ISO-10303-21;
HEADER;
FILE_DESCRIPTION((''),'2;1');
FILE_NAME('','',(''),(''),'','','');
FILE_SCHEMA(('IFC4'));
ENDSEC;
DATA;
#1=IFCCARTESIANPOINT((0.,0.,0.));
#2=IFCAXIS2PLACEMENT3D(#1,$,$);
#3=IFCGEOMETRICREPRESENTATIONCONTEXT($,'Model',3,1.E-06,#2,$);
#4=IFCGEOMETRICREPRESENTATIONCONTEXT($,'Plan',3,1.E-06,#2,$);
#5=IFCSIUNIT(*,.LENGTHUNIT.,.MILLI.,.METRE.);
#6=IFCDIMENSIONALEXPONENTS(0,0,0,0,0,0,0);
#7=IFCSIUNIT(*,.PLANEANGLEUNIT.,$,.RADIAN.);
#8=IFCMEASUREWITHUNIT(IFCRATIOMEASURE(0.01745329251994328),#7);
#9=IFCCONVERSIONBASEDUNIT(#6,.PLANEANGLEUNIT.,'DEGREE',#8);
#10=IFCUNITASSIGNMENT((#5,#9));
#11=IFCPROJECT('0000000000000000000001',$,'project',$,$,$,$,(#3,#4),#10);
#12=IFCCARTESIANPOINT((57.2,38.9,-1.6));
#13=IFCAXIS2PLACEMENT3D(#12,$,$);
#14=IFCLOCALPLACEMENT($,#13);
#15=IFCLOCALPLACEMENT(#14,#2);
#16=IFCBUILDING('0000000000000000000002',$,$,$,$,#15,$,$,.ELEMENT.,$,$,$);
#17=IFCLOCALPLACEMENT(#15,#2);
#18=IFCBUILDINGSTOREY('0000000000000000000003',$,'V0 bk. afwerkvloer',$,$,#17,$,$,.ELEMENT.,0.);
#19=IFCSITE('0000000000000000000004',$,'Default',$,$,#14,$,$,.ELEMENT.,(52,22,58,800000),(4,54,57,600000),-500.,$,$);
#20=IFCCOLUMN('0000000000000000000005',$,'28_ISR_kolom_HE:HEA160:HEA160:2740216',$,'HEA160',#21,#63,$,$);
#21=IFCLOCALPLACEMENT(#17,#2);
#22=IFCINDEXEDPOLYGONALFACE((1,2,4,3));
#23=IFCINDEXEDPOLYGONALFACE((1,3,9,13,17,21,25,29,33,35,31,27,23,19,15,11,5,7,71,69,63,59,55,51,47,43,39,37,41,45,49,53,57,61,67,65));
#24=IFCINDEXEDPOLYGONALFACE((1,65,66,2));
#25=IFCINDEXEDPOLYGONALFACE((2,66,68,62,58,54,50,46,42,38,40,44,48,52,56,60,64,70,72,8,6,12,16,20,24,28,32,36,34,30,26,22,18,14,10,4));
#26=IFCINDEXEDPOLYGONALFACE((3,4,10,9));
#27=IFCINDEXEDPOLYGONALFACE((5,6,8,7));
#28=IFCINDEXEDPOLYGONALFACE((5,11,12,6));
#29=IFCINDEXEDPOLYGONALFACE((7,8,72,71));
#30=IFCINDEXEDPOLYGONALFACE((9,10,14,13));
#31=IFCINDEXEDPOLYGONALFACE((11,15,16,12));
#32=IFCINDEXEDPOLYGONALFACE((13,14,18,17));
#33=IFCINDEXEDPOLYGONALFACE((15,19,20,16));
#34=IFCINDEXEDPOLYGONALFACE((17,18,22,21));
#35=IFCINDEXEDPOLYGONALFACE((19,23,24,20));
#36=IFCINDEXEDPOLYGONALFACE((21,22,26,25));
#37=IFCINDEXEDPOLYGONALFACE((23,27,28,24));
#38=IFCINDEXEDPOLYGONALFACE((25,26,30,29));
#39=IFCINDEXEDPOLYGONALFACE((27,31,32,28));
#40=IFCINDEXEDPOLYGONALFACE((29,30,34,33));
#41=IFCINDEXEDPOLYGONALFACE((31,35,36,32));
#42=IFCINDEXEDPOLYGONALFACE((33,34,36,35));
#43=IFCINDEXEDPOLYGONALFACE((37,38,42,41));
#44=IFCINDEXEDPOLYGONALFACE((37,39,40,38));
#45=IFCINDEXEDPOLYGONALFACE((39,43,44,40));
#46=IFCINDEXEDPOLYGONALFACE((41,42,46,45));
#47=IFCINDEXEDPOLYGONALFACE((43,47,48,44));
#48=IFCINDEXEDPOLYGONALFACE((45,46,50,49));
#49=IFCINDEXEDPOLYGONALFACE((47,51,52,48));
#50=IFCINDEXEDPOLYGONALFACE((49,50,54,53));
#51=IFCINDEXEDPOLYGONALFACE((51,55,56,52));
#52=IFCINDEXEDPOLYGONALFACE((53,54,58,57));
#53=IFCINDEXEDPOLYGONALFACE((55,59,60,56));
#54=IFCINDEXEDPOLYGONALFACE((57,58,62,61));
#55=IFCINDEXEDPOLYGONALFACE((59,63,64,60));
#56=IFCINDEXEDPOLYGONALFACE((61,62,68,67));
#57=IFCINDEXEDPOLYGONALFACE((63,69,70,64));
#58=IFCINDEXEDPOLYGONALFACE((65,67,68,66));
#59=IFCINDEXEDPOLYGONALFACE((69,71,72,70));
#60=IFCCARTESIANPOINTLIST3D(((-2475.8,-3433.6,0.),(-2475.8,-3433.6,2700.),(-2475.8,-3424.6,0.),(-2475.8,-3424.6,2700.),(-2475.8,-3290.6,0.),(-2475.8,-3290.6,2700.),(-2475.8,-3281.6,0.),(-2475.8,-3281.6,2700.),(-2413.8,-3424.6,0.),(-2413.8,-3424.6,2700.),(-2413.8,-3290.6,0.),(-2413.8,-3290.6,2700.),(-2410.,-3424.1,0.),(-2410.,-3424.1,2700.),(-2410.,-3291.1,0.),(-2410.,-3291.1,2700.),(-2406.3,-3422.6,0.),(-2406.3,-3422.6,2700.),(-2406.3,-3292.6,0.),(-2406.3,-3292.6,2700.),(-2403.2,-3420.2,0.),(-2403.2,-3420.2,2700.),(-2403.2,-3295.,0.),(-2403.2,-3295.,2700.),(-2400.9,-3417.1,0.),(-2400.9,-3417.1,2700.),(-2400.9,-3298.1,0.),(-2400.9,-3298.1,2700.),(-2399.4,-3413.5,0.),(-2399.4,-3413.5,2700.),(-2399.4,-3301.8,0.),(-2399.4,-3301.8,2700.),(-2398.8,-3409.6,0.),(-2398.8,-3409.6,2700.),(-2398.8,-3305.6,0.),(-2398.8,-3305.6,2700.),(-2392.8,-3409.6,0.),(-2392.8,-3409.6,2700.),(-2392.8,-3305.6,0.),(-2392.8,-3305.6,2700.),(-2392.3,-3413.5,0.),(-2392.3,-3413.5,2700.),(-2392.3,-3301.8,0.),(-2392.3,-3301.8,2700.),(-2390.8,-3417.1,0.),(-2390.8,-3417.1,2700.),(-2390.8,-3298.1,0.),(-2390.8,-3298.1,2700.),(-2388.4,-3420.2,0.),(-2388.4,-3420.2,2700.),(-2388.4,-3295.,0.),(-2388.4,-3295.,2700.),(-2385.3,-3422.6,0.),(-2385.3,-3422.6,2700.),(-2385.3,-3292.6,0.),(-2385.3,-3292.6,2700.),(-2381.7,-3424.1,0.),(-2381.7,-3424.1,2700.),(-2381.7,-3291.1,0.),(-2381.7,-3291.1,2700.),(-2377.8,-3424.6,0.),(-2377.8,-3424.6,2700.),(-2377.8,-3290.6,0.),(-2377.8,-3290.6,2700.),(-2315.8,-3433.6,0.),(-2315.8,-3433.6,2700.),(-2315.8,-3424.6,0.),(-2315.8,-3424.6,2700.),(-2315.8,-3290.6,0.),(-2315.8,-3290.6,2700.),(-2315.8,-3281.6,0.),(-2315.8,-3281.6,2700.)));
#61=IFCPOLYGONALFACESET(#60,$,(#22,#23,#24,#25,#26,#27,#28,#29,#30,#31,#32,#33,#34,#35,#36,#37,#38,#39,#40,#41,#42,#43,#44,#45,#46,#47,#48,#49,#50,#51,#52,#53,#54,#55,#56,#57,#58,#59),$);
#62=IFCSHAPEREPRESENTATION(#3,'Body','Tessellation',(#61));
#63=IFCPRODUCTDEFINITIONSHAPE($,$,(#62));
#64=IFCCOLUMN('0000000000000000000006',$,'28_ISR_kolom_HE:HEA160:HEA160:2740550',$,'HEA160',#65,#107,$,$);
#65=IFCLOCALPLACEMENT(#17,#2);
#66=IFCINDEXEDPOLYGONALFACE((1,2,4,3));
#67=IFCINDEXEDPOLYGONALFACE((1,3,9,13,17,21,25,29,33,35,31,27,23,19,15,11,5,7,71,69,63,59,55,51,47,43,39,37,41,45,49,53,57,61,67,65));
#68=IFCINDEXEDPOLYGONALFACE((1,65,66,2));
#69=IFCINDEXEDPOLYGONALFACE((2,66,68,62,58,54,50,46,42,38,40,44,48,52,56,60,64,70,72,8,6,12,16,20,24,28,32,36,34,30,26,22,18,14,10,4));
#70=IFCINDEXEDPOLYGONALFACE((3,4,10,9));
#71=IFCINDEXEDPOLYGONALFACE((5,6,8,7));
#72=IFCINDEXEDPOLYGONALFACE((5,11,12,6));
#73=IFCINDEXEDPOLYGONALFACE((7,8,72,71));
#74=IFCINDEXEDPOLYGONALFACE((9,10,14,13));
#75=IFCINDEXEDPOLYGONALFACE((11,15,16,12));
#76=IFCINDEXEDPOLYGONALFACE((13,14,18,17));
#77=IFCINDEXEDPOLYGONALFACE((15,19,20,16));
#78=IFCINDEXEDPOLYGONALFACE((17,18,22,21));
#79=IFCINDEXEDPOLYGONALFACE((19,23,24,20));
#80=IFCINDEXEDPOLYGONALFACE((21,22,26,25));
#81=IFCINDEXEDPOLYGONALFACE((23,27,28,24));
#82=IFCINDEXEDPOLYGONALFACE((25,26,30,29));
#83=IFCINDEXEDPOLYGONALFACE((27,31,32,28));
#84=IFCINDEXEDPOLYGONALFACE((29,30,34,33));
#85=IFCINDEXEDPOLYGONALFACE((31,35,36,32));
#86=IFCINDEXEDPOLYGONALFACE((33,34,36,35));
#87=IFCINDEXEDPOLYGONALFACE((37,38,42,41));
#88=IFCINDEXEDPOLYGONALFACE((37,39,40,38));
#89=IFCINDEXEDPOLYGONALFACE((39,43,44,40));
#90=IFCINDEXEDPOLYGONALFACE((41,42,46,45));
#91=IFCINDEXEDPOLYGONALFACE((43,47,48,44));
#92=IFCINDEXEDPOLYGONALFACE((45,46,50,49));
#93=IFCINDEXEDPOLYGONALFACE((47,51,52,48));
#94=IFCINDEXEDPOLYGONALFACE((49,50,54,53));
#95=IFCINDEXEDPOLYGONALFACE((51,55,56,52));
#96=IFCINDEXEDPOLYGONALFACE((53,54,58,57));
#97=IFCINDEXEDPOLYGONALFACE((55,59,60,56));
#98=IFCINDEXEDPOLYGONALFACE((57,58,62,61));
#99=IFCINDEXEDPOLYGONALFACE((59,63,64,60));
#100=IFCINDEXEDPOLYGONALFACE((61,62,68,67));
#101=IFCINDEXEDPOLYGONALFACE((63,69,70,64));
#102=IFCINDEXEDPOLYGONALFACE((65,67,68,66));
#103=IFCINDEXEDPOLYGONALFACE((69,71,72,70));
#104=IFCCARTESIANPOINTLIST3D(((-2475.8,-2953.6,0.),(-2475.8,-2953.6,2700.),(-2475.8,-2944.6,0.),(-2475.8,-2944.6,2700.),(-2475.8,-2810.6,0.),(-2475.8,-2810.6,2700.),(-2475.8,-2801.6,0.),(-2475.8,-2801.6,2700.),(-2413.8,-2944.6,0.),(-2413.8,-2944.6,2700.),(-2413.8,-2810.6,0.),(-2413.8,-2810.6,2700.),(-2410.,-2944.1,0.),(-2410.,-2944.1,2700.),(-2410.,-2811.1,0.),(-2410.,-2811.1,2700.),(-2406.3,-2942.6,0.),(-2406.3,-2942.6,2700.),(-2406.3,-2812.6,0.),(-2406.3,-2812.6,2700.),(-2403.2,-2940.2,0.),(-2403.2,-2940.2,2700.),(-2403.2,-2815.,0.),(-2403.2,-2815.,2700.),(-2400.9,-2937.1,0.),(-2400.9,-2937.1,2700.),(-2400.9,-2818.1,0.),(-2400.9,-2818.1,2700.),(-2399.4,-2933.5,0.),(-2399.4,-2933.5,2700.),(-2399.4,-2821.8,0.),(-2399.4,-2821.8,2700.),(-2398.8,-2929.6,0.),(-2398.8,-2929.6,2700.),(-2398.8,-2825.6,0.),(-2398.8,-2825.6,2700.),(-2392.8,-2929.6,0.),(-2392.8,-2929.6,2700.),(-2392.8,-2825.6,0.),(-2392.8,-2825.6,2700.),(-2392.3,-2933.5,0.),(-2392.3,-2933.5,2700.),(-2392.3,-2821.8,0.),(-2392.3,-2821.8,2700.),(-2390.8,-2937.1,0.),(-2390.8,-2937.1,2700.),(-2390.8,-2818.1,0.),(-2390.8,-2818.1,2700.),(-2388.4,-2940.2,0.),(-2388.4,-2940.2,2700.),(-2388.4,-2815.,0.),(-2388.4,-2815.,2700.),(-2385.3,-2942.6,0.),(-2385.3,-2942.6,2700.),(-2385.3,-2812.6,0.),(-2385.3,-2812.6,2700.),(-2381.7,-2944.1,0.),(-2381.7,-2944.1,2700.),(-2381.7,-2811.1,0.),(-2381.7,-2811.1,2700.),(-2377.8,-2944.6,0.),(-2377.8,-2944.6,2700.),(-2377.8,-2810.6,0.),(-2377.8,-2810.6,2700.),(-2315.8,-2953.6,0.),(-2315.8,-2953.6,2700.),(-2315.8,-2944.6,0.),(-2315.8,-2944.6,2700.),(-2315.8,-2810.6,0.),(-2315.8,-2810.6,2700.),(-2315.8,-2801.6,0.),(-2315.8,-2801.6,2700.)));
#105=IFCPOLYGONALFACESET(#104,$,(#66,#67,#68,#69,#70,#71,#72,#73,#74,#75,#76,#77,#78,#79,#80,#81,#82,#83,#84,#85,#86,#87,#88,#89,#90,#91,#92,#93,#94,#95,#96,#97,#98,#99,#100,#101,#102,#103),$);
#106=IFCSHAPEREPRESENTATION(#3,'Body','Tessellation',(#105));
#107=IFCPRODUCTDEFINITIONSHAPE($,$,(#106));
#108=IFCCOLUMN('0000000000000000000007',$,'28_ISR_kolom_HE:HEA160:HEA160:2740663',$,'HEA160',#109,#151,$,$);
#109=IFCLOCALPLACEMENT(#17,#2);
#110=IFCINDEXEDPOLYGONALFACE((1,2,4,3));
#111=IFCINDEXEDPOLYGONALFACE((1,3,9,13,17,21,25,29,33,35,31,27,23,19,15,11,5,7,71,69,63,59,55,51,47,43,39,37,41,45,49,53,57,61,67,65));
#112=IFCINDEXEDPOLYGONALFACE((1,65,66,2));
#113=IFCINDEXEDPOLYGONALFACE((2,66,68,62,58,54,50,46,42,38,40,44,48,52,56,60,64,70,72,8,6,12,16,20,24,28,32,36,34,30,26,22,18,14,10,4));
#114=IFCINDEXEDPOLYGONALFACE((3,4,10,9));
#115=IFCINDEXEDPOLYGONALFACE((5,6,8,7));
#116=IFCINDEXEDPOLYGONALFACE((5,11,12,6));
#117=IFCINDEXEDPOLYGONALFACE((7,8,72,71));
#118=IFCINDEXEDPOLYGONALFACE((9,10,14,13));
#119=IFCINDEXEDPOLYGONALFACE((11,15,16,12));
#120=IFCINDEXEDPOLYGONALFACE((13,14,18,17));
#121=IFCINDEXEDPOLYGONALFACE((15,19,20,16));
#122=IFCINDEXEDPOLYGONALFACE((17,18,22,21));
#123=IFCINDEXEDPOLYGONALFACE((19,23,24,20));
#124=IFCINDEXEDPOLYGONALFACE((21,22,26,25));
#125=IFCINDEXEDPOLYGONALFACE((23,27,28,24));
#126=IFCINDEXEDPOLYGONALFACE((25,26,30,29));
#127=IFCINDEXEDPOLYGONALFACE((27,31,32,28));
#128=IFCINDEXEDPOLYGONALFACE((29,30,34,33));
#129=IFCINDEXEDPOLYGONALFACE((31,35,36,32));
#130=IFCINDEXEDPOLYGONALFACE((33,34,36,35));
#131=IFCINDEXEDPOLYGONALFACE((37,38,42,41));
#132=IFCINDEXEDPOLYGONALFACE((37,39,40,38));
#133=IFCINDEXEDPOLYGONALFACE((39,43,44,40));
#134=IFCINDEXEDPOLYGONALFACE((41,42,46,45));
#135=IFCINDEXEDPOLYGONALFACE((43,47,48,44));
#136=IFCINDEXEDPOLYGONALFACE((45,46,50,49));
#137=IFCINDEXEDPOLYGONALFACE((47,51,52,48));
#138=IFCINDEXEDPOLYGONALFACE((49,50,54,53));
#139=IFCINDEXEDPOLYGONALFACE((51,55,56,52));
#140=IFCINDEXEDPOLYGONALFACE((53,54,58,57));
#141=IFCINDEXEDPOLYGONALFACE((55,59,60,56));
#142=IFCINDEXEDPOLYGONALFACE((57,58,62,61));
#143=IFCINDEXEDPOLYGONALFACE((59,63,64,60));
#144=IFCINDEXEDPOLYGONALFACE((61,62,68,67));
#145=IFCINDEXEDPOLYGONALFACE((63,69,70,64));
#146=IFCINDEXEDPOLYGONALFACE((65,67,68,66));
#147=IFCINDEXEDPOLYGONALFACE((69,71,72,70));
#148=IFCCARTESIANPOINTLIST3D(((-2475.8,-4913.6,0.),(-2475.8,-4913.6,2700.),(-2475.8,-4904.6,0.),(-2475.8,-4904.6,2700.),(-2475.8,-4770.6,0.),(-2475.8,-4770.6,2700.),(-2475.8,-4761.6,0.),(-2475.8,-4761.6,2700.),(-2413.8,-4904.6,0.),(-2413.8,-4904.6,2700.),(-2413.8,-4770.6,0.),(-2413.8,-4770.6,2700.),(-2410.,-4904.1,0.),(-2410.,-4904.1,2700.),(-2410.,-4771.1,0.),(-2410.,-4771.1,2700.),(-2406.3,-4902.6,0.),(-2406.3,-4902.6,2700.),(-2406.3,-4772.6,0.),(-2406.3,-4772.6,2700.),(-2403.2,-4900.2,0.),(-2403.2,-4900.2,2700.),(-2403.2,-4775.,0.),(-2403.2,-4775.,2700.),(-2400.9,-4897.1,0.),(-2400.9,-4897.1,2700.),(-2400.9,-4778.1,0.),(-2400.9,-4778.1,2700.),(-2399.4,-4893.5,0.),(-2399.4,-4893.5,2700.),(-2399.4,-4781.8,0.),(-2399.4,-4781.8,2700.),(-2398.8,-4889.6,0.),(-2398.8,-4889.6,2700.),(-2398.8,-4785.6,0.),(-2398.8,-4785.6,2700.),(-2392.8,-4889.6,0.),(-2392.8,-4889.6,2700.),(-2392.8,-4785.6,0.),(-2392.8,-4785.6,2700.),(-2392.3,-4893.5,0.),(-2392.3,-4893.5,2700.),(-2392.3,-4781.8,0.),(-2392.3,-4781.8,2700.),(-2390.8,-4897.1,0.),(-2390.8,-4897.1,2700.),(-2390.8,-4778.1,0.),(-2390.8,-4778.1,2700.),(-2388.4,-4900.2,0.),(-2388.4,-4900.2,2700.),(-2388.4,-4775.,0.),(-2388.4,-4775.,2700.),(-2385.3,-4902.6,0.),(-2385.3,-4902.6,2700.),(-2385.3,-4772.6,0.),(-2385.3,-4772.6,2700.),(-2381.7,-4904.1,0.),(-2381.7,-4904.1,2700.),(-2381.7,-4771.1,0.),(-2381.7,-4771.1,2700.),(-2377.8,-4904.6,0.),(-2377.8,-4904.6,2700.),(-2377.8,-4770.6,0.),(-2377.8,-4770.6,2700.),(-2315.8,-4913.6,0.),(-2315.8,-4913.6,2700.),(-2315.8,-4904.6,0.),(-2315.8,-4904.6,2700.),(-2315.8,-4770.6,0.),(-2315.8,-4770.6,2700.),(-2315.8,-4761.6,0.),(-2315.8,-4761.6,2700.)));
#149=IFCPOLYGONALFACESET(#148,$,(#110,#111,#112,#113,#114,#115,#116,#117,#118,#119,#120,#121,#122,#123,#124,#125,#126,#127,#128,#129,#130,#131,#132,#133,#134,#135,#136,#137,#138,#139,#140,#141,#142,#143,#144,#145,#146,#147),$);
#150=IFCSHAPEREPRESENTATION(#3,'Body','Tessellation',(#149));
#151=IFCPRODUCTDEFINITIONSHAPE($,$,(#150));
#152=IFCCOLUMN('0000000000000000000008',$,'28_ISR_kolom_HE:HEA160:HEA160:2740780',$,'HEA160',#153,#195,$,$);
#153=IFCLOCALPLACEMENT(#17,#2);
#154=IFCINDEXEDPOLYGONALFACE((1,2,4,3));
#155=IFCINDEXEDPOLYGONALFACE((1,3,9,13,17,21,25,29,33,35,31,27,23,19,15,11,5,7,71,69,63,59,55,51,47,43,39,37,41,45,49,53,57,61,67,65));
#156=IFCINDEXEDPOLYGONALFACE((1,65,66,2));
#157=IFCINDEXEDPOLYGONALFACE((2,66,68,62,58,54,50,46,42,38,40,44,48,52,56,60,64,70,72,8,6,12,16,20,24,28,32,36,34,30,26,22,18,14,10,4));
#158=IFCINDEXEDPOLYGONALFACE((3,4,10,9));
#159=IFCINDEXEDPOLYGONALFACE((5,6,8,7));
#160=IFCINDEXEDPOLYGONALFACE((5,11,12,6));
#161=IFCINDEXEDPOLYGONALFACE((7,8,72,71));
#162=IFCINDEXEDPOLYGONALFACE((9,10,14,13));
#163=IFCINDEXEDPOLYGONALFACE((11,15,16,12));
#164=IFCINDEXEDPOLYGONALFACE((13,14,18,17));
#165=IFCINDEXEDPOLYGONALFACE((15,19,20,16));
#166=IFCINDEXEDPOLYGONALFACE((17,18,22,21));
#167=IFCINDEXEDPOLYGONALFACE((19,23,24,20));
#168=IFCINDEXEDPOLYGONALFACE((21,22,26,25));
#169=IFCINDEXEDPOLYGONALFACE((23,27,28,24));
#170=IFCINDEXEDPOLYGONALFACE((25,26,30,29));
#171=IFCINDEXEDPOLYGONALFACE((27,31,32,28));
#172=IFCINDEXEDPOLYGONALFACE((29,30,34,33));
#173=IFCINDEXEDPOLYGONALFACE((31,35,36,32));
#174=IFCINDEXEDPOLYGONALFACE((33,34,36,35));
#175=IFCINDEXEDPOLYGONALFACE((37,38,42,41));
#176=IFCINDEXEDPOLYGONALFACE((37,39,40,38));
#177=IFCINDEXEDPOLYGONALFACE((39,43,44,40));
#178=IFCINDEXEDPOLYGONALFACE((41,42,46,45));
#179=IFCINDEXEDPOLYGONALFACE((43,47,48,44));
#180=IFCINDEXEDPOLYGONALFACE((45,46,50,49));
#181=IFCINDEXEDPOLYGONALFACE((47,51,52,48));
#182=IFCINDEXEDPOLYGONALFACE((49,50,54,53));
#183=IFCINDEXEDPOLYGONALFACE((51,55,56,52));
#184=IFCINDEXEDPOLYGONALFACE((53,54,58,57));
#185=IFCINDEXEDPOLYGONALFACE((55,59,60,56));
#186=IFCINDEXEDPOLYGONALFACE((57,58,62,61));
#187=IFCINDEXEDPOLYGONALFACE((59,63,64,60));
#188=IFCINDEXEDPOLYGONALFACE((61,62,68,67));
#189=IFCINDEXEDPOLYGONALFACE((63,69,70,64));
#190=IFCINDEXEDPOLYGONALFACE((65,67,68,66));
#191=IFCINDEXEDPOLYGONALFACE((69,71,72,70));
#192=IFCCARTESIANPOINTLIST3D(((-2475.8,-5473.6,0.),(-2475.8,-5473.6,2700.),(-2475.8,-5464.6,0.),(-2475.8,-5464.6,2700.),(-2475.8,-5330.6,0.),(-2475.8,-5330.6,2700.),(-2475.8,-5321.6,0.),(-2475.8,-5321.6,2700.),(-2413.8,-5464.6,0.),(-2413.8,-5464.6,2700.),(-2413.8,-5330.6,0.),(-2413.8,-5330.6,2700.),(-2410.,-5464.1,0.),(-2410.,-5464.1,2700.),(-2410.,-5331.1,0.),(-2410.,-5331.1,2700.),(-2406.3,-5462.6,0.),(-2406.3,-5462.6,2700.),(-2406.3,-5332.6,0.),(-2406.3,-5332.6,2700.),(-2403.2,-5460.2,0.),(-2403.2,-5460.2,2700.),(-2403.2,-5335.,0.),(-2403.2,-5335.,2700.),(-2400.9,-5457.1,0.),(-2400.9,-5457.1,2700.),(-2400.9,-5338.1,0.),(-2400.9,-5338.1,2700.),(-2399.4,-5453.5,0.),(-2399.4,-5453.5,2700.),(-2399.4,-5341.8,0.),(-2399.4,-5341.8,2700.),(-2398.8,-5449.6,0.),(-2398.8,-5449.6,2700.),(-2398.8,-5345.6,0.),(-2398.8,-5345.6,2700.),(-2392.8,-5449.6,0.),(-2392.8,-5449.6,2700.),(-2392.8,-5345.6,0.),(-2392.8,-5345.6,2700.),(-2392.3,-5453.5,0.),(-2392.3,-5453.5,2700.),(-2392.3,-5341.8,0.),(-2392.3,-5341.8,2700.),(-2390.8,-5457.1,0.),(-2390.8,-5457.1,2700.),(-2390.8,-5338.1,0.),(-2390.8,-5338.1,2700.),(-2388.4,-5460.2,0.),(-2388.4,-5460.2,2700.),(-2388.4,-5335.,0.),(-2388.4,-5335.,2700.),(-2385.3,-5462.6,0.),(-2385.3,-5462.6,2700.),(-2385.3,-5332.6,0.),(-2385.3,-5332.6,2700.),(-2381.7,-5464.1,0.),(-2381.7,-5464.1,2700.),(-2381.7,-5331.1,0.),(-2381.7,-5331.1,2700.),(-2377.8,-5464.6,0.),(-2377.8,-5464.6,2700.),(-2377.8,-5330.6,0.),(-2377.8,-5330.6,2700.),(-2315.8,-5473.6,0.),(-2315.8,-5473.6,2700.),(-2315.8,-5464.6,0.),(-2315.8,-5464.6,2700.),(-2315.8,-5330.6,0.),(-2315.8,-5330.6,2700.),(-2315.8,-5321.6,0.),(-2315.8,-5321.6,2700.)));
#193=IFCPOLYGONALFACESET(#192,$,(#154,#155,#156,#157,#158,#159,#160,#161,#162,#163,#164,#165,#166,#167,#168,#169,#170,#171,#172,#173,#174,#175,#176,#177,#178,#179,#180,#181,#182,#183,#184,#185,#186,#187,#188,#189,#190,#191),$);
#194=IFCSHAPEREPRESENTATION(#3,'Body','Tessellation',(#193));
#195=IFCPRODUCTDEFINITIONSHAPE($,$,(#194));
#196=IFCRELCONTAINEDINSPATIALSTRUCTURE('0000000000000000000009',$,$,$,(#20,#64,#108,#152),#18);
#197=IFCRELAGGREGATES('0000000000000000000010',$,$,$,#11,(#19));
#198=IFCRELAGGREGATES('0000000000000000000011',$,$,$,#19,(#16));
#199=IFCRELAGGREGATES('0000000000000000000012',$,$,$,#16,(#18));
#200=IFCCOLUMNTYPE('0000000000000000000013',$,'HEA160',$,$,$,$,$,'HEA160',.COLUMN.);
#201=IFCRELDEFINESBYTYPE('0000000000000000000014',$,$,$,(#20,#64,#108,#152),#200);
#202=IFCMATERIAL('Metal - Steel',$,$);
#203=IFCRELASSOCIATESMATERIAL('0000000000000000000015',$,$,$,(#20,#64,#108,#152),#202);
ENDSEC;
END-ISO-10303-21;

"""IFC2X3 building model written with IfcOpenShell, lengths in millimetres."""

from ifc_helpers import new_model, entity, si_unit, converted_unit, frame, frame_2d, origin, place, context, project, spatial, polyline, circle_curve, parameter, trimmed, segment, composite_curve, outline, extrude, source, transform, mapped, material, type_object, type_shapes, element, save


model = new_model("IFC2X3")

# Units and contexts
model_context = context("Model", 3, precision=1e-06, world=origin())
plan_context = context("Plan", 3, precision=1e-06, world=origin())
ifc_project = project(units=[si_unit("LENGTHUNIT", "METRE", prefix="MILLI"), converted_unit("PLANEANGLEUNIT", "DEGREE", entity("IfcRatioMeasure", 0.01745329251994328), si_unit("PLANEANGLEUNIT", "RADIAN"), dimensions=[0, 0, 0, 0, 0, 0, 0])], contexts=[model_context, plan_context])

# Site, building, storey
site_placement = place(None, frame((57.2, 38.9, -1.6)))
site = spatial("IfcSite", under=ifc_project, at=site_placement, Name="Default", CompositionType="ELEMENT", RefLatitude=(52, 22, 58, 800000), RefLongitude=(4, 54, 57, 600000), RefElevation=-500.0)
building_placement = place(site_placement, origin())
building = spatial("IfcBuilding", under=site, at=building_placement, CompositionType="ELEMENT")
storey_placement = place(building_placement, origin())
storey = spatial("IfcBuildingStorey", under=building, at=storey_placement, Name="V0 bk. afwerkvloer", CompositionType="ELEMENT", Elevation=0.0)

# Columns
ifc_material_1 = material(Name="Metal - Steel")
column_type = type_object("IfcColumnType", Name="HEA160", ElementType="HEA160", PredefinedType="COLUMN")
shared_shape_1 = source(origin(), model_context, "Body", "SweptSolid", [
    extrude(outline(composite_curve([segment(polyline([(-80.0, -76.0), (80.0, -76.0)]), True, "CONTINUOUS"), segment(polyline([(80.0, -76.0), (80.0, -67.0)]), True, "CONTINUOUS"), segment(polyline([(80.0, -67.0), (18.0, -67.0)]), True, "CONTINUOUS"), segment(trimmed(circle_curve(frame_2d((18.0, -52.0), x_axis=(-1.0, 0.0)), 15.0), [parameter(0.0)], [parameter(90.0)], True, "PARAMETER"), False, "CONTINUOUS"), segment(polyline([(3.0, -52.0), (3.0, 52.0)]), True, "CONTINUOUS"), segment(trimmed(circle_curve(frame_2d((18.0, 52.0), x_axis=(-1.0, 0.0)), 15.0), [parameter(270.0)], [parameter(0.0)], True, "PARAMETER"), False, "CONTINUOUS"), segment(polyline([(18.0, 67.0), (80.0, 67.0)]), True, "CONTINUOUS"), segment(polyline([(80.0, 67.0), (80.0, 76.0)]), True, "CONTINUOUS"), segment(polyline([(80.0, 76.0), (-80.0, 76.0)]), True, "CONTINUOUS"), segment(polyline([(-80.0, 76.0), (-80.0, 67.0)]), True, "CONTINUOUS"), segment(polyline([(-80.0, 67.0), (-18.0, 67.0)]), True, "CONTINUOUS"), segment(trimmed(circle_curve(frame_2d((-18.0, 52.0), x_axis=(-1.0, 0.0)), 15.0), [parameter(180.0)], [parameter(270.0)], True, "PARAMETER"), False, "CONTINUOUS"), segment(polyline([(-3.0, 52.0), (-3.0, -52.0)]), True, "CONTINUOUS"), segment(trimmed(circle_curve(frame_2d((-18.0, -52.0), x_axis=(-1.0, 0.0)), 15.0), [parameter(90.0)], [parameter(180.0)], True, "PARAMETER"), False, "CONTINUOUS"), segment(polyline([(-18.0, -67.0), (-80.0, -67.0)]), True, "CONTINUOUS"), segment(polyline([(-80.0, -67.0), (-80.0, -76.0)]), True, "CONTINUOUS")], self_intersect=False)), frame((0.0, 0.0, 0.0), z_axis=(0.0, 0.0, 1.0), x_axis=(-1.0, 0.0, 0.0)), (0.0, 0.0, 1.0), 2700.0),
])
type_shapes(column_type, [shared_shape_1])
for number, where, name in (
    (1, (-2395.8, -3357.6, 0.0), "28_ISR_kolom_HE:HEA160:HEA160:2740216"),
    (2, (-2395.8, -2877.6, 0.0), "28_ISR_kolom_HE:HEA160:HEA160:2740550"),
    (3, (-2395.8, -4837.6, 0.0), "28_ISR_kolom_HE:HEA160:HEA160:2740663"),
    (4, (-2395.8, -5397.6, 0.0), "28_ISR_kolom_HE:HEA160:HEA160:2740780"),
):
    element("IfcColumn", number, at=place(storey_placement, frame(where)), inside=storey, type_object=column_type, material=ifc_material_1, Name=name, ObjectType="HEA160", context=model_context, shape_type="MappedRepresentation", body=[
        mapped(shared_shape_1, transform((0.0, 0.0, 0.0), scale=1.0)),
    ])

save(model, "model.ifc")
